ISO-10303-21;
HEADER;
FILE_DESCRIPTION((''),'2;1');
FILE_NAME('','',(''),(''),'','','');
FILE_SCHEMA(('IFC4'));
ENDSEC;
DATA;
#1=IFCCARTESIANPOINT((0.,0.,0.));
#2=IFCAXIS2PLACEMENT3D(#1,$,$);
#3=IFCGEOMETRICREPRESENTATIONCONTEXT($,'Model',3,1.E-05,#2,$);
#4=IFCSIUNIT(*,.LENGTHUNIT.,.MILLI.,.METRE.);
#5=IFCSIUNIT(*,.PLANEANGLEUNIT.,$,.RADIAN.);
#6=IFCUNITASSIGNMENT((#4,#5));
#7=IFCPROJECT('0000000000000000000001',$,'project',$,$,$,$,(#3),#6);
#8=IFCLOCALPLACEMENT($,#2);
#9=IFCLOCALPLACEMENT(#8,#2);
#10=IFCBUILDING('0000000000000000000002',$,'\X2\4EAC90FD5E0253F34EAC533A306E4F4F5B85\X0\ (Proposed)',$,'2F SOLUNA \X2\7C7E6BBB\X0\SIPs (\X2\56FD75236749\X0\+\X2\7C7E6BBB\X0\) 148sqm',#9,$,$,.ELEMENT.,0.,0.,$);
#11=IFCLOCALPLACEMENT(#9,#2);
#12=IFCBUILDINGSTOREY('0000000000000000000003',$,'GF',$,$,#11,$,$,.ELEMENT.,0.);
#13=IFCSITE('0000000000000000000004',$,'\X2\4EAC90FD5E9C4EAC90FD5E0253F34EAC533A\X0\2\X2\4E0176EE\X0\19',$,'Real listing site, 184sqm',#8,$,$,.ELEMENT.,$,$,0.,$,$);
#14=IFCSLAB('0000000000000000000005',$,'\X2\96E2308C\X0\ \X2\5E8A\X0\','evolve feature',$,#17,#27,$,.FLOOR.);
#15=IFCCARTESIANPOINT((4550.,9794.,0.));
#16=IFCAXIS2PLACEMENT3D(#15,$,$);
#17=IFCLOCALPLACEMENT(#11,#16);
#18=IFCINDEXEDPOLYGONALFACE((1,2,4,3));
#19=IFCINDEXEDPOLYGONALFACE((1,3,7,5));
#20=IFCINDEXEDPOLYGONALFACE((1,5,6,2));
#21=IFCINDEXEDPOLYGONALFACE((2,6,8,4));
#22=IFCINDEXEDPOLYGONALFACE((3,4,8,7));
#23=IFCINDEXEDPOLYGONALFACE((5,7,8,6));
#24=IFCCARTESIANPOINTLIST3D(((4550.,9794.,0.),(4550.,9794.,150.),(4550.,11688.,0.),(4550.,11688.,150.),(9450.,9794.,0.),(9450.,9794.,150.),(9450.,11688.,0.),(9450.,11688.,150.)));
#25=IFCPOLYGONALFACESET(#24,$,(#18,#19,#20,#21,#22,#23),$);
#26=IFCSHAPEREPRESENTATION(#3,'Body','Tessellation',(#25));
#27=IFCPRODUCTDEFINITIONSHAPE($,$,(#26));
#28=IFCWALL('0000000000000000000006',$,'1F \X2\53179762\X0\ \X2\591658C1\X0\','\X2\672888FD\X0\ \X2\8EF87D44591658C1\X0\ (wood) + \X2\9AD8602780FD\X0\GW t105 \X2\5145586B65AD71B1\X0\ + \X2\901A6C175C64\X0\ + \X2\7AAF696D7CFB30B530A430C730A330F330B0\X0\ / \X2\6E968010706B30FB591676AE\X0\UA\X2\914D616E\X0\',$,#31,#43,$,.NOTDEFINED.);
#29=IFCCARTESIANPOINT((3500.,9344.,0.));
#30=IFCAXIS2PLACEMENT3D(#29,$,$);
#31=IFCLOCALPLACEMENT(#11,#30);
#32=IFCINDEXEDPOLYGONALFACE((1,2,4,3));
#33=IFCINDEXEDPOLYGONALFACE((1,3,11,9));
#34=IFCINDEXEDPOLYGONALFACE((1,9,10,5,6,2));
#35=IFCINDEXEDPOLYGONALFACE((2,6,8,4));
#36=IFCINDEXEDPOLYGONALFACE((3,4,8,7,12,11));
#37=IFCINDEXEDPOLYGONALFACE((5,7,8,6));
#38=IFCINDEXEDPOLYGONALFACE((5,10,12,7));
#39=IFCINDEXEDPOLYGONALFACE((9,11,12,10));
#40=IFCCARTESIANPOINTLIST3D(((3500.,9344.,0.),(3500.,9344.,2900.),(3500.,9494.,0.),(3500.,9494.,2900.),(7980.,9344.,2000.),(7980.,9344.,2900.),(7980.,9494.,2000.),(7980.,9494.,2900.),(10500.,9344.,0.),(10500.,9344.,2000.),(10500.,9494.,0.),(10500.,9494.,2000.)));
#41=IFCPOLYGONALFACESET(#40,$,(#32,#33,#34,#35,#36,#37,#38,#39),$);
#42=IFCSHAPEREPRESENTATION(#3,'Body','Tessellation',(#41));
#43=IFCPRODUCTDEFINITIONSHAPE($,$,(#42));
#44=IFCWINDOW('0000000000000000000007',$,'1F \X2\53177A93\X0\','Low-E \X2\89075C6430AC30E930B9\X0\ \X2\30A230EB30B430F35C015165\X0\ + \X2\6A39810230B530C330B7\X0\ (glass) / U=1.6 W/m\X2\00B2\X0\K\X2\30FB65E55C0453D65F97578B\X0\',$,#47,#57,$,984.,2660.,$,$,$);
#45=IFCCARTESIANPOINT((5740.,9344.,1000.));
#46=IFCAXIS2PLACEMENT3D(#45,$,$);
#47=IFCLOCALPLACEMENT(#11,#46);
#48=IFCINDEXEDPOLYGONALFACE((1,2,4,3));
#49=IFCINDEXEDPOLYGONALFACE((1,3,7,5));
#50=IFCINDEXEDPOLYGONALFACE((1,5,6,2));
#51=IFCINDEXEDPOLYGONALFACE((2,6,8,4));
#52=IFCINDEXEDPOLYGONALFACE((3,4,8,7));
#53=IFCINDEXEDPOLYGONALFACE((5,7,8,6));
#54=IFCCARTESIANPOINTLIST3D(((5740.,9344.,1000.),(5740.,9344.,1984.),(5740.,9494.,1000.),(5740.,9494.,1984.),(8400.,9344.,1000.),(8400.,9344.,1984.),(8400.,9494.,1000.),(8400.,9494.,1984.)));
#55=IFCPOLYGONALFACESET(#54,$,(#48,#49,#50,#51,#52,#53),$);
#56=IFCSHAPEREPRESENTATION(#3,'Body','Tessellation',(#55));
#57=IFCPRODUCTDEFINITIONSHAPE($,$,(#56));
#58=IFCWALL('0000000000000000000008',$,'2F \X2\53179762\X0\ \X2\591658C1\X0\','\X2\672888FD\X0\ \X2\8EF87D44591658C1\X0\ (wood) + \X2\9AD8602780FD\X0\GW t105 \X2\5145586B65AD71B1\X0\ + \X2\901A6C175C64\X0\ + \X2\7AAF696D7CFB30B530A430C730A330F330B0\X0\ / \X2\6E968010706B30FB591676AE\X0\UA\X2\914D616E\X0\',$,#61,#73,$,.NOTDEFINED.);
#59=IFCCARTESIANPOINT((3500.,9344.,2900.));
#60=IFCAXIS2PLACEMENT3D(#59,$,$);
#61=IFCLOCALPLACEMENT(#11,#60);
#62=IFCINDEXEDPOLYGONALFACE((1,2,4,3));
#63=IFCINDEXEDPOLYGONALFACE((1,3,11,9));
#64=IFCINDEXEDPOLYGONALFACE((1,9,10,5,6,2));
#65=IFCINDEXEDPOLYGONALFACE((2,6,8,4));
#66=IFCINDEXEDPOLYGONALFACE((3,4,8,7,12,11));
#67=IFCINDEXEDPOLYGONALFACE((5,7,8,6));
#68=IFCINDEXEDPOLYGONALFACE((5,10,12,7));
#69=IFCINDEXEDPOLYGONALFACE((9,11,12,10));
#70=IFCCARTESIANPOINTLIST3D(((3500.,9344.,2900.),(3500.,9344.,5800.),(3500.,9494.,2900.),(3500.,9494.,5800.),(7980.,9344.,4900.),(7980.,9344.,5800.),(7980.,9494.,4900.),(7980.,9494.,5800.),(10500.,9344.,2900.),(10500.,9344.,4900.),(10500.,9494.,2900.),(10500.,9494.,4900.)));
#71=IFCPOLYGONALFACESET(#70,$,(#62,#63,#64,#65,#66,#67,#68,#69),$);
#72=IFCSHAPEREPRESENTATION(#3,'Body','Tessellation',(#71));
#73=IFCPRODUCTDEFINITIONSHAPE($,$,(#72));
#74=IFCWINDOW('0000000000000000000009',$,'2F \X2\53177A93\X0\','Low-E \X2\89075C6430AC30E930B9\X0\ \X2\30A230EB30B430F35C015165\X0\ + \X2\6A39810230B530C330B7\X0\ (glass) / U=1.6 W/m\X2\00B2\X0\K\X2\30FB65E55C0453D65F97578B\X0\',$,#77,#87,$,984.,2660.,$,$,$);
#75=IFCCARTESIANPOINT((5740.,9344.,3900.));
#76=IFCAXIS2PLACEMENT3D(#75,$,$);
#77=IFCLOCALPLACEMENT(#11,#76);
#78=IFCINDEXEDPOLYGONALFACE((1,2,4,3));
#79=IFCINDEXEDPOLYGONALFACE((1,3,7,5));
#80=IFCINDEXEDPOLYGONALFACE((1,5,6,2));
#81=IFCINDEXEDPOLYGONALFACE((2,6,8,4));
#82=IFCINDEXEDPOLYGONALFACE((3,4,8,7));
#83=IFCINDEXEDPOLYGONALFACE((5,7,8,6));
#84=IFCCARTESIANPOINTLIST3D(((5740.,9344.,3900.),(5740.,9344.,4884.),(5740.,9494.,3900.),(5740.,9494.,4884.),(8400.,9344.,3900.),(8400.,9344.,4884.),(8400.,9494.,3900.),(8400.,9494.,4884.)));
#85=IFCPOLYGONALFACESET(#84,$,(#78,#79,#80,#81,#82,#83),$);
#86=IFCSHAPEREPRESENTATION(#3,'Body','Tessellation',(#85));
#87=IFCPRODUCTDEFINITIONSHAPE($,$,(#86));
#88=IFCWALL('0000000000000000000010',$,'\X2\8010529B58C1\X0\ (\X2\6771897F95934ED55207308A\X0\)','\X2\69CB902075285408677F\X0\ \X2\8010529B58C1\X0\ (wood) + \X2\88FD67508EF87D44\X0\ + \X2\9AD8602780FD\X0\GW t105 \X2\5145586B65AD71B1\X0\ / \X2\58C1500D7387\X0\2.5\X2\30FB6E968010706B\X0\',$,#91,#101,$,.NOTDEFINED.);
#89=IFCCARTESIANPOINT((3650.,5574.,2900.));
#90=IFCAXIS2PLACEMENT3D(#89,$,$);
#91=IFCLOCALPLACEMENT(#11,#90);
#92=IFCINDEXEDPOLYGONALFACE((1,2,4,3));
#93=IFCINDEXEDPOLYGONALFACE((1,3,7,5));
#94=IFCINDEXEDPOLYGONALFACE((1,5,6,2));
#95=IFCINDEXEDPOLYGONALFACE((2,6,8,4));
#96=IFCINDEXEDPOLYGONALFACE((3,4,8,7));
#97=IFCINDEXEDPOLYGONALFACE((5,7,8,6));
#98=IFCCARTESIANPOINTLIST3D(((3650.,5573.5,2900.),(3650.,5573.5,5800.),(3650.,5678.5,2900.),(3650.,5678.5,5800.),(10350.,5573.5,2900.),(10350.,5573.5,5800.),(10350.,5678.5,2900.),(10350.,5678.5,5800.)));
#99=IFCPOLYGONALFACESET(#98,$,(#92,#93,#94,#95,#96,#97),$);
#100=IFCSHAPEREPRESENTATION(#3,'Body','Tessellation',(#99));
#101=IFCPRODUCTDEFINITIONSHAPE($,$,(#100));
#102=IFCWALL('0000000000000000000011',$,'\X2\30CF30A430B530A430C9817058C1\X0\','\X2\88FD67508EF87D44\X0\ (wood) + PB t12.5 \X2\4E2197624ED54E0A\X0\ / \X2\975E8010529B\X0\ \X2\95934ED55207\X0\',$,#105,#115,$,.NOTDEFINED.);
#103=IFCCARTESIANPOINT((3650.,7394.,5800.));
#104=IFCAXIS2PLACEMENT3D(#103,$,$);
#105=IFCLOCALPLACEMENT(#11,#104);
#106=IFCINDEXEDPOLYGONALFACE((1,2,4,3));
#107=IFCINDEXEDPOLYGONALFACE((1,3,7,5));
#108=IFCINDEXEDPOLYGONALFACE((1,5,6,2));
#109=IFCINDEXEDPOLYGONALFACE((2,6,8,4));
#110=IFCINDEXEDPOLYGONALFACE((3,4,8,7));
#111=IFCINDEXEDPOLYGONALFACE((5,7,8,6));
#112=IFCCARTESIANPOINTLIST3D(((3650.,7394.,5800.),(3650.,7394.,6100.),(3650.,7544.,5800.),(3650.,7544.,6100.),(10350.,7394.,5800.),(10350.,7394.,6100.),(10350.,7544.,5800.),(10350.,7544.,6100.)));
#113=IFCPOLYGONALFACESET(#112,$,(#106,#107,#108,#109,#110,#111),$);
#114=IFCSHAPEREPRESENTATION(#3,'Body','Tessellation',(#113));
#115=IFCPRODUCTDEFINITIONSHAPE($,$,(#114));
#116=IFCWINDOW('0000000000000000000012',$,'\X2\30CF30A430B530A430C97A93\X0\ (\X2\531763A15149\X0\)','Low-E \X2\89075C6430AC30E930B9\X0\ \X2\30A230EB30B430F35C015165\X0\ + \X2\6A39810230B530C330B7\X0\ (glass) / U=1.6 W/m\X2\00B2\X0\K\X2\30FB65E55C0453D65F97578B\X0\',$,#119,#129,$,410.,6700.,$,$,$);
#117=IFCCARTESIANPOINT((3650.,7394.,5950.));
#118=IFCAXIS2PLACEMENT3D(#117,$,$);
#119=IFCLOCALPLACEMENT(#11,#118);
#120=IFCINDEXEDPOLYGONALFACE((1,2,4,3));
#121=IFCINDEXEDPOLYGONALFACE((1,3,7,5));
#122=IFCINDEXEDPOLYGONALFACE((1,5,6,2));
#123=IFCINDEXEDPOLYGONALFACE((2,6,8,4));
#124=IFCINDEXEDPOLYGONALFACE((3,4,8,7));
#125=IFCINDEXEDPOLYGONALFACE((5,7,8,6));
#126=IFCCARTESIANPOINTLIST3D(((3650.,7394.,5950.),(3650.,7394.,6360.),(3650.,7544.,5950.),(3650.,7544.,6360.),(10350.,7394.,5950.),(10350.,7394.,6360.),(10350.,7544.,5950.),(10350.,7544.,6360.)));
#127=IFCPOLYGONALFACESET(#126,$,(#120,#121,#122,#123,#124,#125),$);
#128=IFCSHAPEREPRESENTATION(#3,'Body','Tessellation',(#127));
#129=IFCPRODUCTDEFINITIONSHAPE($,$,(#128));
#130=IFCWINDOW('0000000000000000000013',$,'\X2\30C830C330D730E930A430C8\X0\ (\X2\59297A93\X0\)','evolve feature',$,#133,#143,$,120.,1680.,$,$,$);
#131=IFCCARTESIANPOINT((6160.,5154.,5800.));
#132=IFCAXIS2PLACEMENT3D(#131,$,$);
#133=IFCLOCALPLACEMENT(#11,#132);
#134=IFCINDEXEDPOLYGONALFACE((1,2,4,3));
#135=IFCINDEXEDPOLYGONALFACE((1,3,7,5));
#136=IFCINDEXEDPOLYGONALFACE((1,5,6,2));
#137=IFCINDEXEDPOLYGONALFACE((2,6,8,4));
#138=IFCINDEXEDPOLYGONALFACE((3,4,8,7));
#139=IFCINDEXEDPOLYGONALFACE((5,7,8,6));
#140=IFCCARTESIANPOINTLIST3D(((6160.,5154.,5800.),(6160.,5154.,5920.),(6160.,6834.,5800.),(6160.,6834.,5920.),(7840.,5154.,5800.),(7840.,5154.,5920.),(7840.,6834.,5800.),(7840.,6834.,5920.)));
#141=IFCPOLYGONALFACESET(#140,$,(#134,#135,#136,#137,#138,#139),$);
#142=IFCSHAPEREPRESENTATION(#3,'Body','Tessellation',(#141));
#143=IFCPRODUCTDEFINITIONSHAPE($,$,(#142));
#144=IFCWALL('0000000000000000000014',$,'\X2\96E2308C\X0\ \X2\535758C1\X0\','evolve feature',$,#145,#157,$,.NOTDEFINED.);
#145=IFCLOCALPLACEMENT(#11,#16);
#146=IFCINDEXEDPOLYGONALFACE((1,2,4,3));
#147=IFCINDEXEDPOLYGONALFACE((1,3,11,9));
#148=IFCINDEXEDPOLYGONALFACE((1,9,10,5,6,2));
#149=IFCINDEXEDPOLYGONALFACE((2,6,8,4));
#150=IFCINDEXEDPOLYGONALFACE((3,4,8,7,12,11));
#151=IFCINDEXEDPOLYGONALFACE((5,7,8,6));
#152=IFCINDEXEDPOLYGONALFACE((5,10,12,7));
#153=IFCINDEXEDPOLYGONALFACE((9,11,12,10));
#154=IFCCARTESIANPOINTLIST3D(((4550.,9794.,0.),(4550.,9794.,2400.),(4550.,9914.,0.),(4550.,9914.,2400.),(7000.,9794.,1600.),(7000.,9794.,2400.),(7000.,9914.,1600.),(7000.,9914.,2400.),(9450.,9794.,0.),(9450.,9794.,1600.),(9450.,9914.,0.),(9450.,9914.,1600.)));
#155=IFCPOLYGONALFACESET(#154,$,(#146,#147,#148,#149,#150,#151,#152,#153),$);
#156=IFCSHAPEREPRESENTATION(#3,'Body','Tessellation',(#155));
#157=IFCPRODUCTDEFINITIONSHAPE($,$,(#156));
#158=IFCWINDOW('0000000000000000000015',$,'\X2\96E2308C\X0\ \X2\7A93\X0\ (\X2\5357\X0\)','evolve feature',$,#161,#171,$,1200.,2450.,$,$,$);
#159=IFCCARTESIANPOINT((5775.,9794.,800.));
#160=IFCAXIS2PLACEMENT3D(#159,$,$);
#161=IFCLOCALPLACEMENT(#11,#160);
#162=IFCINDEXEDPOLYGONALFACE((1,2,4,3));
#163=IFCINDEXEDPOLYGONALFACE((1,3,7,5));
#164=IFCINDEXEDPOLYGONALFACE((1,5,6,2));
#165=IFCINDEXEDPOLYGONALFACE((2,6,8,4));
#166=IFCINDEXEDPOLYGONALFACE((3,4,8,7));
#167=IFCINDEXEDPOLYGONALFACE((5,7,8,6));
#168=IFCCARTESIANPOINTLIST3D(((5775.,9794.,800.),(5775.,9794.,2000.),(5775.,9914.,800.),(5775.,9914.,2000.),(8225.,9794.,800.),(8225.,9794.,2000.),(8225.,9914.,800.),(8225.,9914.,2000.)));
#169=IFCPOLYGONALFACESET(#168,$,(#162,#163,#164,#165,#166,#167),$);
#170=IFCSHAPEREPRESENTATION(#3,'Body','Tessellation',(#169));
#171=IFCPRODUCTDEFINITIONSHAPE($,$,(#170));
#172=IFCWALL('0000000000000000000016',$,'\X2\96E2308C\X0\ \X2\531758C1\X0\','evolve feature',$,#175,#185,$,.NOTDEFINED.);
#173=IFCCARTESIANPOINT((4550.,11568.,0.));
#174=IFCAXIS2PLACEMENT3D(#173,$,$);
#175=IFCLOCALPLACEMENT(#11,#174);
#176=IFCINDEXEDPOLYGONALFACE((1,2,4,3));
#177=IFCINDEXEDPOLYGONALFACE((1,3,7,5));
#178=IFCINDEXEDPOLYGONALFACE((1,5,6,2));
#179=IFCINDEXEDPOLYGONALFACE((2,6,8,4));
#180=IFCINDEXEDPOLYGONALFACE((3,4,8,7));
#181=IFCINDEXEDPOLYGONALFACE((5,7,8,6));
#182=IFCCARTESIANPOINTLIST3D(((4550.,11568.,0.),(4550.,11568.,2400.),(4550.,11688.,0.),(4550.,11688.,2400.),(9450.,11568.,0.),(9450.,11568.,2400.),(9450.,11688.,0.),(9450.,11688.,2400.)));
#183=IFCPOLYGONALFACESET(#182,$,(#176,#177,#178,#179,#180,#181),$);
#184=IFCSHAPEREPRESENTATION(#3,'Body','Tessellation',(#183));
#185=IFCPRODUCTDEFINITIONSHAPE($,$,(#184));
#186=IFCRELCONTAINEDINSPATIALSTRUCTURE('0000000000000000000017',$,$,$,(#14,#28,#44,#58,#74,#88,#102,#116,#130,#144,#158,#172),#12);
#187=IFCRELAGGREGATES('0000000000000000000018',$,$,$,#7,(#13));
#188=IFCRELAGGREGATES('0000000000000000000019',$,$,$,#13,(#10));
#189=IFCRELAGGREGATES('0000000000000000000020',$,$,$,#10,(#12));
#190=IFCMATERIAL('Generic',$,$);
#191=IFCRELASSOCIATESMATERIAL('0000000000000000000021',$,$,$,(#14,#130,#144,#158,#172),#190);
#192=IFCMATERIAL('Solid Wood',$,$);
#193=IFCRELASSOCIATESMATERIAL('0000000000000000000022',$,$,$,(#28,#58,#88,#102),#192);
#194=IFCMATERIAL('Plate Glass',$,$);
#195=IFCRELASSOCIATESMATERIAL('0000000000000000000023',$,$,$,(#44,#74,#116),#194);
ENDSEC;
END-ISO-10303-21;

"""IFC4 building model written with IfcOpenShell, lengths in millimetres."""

from ifc_helpers import new_model, si_unit, frame, frame_2d, origin, place, context, project, spatial, rectangle, extrude, material, element, fill, save


model = new_model("IFC4")

# Units and contexts
model_context = context("Model", 3, precision=1e-05, world=origin())
ifc_project = project(units=[si_unit("LENGTHUNIT", "METRE", prefix="MILLI"), si_unit("PLANEANGLEUNIT", "RADIAN")], contexts=[model_context])

# Site, building, storey
site_placement = place(None, origin())
site = spatial("IfcSite", under=ifc_project, at=site_placement, Name="京都府京都市右京区2丁目19", ObjectType="Real listing site, 184sqm", CompositionType="ELEMENT", RefElevation=0.0)
building_placement = place(site_placement, origin())
building = spatial("IfcBuilding", under=site, at=building_placement, Name="京都市右京区の住宅 (Proposed)", ObjectType="2F SOLUNA 籾殻SIPs (国産杉+籾殻) 148sqm", CompositionType="ELEMENT", ElevationOfRefHeight=0.0, ElevationOfTerrain=0.0)
storey_placement = place(building_placement, origin())
storey = spatial("IfcBuildingStorey", under=building, at=storey_placement, Name="GF", CompositionType="ELEMENT", Elevation=0.0)

# Slab
ifc_material_1 = material(Name="Generic")
slab_placement = place(storey_placement, frame((4550.0, 9794.0, 0.0)))
element("IfcSlab", 1, at=slab_placement, inside=storey, material=ifc_material_1, Name="離れ 床", Description="evolve feature", PredefinedType="FLOOR", context=model_context, shape_type="SweptSolid", body=[
    extrude(rectangle(XDim=4900.0, YDim=1894.0, at=frame_2d((2450.0, 947.0))), frame((4550.0, 9794.0, 0.0)), (0.0, 0.0, 1.0), 150.0),
])

# Wall, opening, window
ifc_material_2 = material(Name="Solid Wood")
wall_1_placement = place(storey_placement, frame((3500.0, 9344.0, 0.0)))
wall_1 = element("IfcWall", 2, at=wall_1_placement, inside=storey, material=ifc_material_2, Name="1F 北面 外壁", Description="木製 軸組外壁 (wood) + 高性能GW t105 充填断熱 + 通気層 + 窯業系サイディング / 準耐火・外皮UA配慮", PredefinedType="NOTDEFINED", context=model_context, shape_type="SweptSolid", body=[
    extrude(rectangle(XDim=7000.0, YDim=150.0, at=frame_2d((3500.0, 75.0))), frame((3500.0, 9344.0, 0.0)), (0.0, 0.0, 1.0), 2900.0),
])
opening_1_placement = place(storey_placement, frame((5740.0, 9344.0, 1000.0)))
opening_1 = element("IfcOpeningElement", 3, at=opening_1_placement, cuts=wall_1, PredefinedType="NOTDEFINED", context=model_context, shape_type="SweptSolid", body=[
    extrude(rectangle(XDim=2660.0, YDim=150.0, at=frame_2d((1330.0, 75.0))), frame((5740.0, 9344.0, 1000.0)), (0.0, 0.0, 1.0), 984.0),
])
ifc_material_3 = material(Name="Plate Glass")
window_1_placement = place(storey_placement, frame((5740.0, 9344.0, 1000.0)))
window_1 = element("IfcWindow", 4, at=window_1_placement, inside=storey, material=ifc_material_3, Name="1F 北窓", Description="Low-E 複層ガラス アルゴン封入 + 樹脂サッシ (glass) / U=1.6 W/m²K・日射取得型", OverallHeight=984.0, OverallWidth=2660.0, context=model_context, shape_type="SweptSolid", body=[
    extrude(rectangle(XDim=2660.0, YDim=150.0, at=frame_2d((1330.0, 75.0))), frame((5740.0, 9344.0, 1000.0)), (0.0, 0.0, 1.0), 984.0),
])
fill(opening_1, window_1)

# Wall, opening, window
wall_2_placement = place(storey_placement, frame((3500.0, 9344.0, 2900.0)))
wall_2 = element("IfcWall", 5, at=wall_2_placement, inside=storey, material=ifc_material_2, Name="2F 北面 外壁", Description="木製 軸組外壁 (wood) + 高性能GW t105 充填断熱 + 通気層 + 窯業系サイディング / 準耐火・外皮UA配慮", PredefinedType="NOTDEFINED", context=model_context, shape_type="SweptSolid", body=[
    extrude(rectangle(XDim=7000.0, YDim=150.0, at=frame_2d((3500.0, 75.0))), frame((3500.0, 9344.0, 2900.0)), (0.0, 0.0, 1.0), 2900.0),
])
opening_2_placement = place(storey_placement, frame((5740.0, 9344.0, 3900.0)))
opening_2 = element("IfcOpeningElement", 6, at=opening_2_placement, cuts=wall_2, PredefinedType="NOTDEFINED", context=model_context, shape_type="SweptSolid", body=[
    extrude(rectangle(XDim=2660.0, YDim=150.0, at=frame_2d((1330.0, 75.0))), frame((5740.0, 9344.0, 3900.0)), (0.0, 0.0, 1.0), 984.0),
])
window_2_placement = place(storey_placement, frame((5740.0, 9344.0, 3900.0)))
window_2 = element("IfcWindow", 7, at=window_2_placement, inside=storey, material=ifc_material_3, Name="2F 北窓", Description="Low-E 複層ガラス アルゴン封入 + 樹脂サッシ (glass) / U=1.6 W/m²K・日射取得型", OverallHeight=984.0, OverallWidth=2660.0, context=model_context, shape_type="SweptSolid", body=[
    extrude(rectangle(XDim=2660.0, YDim=150.0, at=frame_2d((1330.0, 75.0))), frame((5740.0, 9344.0, 3900.0)), (0.0, 0.0, 1.0), 984.0),
])
fill(opening_2, window_2)

# Wall
wall_3_placement = place(storey_placement, frame((3650.0, 5574.0, 2900.0)))
element("IfcWall", 8, at=wall_3_placement, inside=storey, material=ifc_material_2, Name="耐力壁 (東西間仕切り)", Description="構造用合板 耐力壁 (wood) + 製材軸組 + 高性能GW t105 充填断熱 / 壁倍率2.5・準耐火", PredefinedType="NOTDEFINED", context=model_context, shape_type="SweptSolid", body=[
    extrude(rectangle(XDim=6700.0, YDim=105.0, at=frame_2d((3350.0, 52.0))), frame((3650.0, 5574.0, 2900.0)), (0.0, 0.0, 1.0), 2900.0),
])

# Wall, opening, window
wall_4_placement = place(storey_placement, frame((3650.0, 7394.0, 5800.0)))
wall_4 = element("IfcWall", 9, at=wall_4_placement, inside=storey, material=ifc_material_2, Name="ハイサイド腰壁", Description="製材軸組 (wood) + PB t12.5 両面仕上 / 非耐力 間仕切", PredefinedType="NOTDEFINED", context=model_context, shape_type="SweptSolid", body=[
    extrude(rectangle(XDim=6700.0, YDim=150.0, at=frame_2d((3350.0, 75.0))), frame((3650.0, 7394.0, 5800.0)), (0.0, 0.0, 1.0), 700.0),
])
opening_3_placement = place(storey_placement, frame((3650.0, 7394.0, 5950.0)))
opening_3 = element("IfcOpeningElement", 10, at=opening_3_placement, cuts=wall_4, PredefinedType="NOTDEFINED", context=model_context, shape_type="SweptSolid", body=[
    extrude(rectangle(XDim=6700.0, YDim=150.0, at=frame_2d((3350.0, 75.0))), frame((3650.0, 7394.0, 5950.0)), (0.0, 0.0, 1.0), 410.0),
])
window_3_placement = place(storey_placement, frame((3650.0, 7394.0, 5950.0)))
window_3 = element("IfcWindow", 11, at=window_3_placement, inside=storey, material=ifc_material_3, Name="ハイサイド窓 (北採光)", Description="Low-E 複層ガラス アルゴン封入 + 樹脂サッシ (glass) / U=1.6 W/m²K・日射取得型", OverallHeight=410.0, OverallWidth=6700.0, context=model_context, shape_type="SweptSolid", body=[
    extrude(rectangle(XDim=6700.0, YDim=150.0, at=frame_2d((3350.0, 75.0))), frame((3650.0, 7394.0, 5950.0)), (0.0, 0.0, 1.0), 410.0),
])
fill(opening_3, window_3)

# Window
window_4_placement = place(storey_placement, frame((6160.0, 5154.0, 5800.0)))
element("IfcWindow", 12, at=window_4_placement, inside=storey, material=ifc_material_1, Name="トップライト (天窓)", Description="evolve feature", OverallHeight=120.0, OverallWidth=1680.0, context=model_context, shape_type="SweptSolid", body=[
    extrude(rectangle(XDim=1680.0, YDim=1680.0, at=frame_2d((840.0, 840.0))), frame((6160.0, 5154.0, 5800.0)), (0.0, 0.0, 1.0), 120.0),
])

# Wall, opening, window
wall_5_placement = place(storey_placement, frame((4550.0, 9794.0, 0.0)))
wall_5 = element("IfcWall", 13, at=wall_5_placement, inside=storey, material=ifc_material_1, Name="離れ 南壁", Description="evolve feature", PredefinedType="NOTDEFINED", context=model_context, shape_type="SweptSolid", body=[
    extrude(rectangle(XDim=4900.0, YDim=120.0, at=frame_2d((2450.0, 60.0))), frame((4550.0, 9794.0, 0.0)), (0.0, 0.0, 1.0), 2400.0),
])
opening_4_placement = place(storey_placement, frame((5775.0, 9794.0, 800.0)))
opening_4 = element("IfcOpeningElement", 14, at=opening_4_placement, cuts=wall_5, PredefinedType="NOTDEFINED", context=model_context, shape_type="SweptSolid", body=[
    extrude(rectangle(XDim=2450.0, YDim=120.0, at=frame_2d((1225.0, 60.0))), frame((5775.0, 9794.0, 800.0)), (0.0, 0.0, 1.0), 1200.0),
])
window_5_placement = place(storey_placement, frame((5775.0, 9794.0, 800.0)))
window_5 = element("IfcWindow", 15, at=window_5_placement, inside=storey, material=ifc_material_1, Name="離れ 窓 (南)", Description="evolve feature", OverallHeight=1200.0, OverallWidth=2450.0, context=model_context, shape_type="SweptSolid", body=[
    extrude(rectangle(XDim=2450.0, YDim=120.0, at=frame_2d((1225.0, 60.0))), frame((5775.0, 9794.0, 800.0)), (0.0, 0.0, 1.0), 1200.0),
])
fill(opening_4, window_5)

# Wall
wall_6_placement = place(storey_placement, frame((4550.0, 11568.0, 0.0)))
element("IfcWall", 16, at=wall_6_placement, inside=storey, material=ifc_material_1, Name="離れ 北壁", Description="evolve feature", PredefinedType="NOTDEFINED", context=model_context, shape_type="SweptSolid", body=[
    extrude(rectangle(XDim=4900.0, YDim=120.0, at=frame_2d((2450.0, 60.0))), frame((4550.0, 11568.0, 0.0)), (0.0, 0.0, 1.0), 2400.0),
])

save(model, "model.ifc")
